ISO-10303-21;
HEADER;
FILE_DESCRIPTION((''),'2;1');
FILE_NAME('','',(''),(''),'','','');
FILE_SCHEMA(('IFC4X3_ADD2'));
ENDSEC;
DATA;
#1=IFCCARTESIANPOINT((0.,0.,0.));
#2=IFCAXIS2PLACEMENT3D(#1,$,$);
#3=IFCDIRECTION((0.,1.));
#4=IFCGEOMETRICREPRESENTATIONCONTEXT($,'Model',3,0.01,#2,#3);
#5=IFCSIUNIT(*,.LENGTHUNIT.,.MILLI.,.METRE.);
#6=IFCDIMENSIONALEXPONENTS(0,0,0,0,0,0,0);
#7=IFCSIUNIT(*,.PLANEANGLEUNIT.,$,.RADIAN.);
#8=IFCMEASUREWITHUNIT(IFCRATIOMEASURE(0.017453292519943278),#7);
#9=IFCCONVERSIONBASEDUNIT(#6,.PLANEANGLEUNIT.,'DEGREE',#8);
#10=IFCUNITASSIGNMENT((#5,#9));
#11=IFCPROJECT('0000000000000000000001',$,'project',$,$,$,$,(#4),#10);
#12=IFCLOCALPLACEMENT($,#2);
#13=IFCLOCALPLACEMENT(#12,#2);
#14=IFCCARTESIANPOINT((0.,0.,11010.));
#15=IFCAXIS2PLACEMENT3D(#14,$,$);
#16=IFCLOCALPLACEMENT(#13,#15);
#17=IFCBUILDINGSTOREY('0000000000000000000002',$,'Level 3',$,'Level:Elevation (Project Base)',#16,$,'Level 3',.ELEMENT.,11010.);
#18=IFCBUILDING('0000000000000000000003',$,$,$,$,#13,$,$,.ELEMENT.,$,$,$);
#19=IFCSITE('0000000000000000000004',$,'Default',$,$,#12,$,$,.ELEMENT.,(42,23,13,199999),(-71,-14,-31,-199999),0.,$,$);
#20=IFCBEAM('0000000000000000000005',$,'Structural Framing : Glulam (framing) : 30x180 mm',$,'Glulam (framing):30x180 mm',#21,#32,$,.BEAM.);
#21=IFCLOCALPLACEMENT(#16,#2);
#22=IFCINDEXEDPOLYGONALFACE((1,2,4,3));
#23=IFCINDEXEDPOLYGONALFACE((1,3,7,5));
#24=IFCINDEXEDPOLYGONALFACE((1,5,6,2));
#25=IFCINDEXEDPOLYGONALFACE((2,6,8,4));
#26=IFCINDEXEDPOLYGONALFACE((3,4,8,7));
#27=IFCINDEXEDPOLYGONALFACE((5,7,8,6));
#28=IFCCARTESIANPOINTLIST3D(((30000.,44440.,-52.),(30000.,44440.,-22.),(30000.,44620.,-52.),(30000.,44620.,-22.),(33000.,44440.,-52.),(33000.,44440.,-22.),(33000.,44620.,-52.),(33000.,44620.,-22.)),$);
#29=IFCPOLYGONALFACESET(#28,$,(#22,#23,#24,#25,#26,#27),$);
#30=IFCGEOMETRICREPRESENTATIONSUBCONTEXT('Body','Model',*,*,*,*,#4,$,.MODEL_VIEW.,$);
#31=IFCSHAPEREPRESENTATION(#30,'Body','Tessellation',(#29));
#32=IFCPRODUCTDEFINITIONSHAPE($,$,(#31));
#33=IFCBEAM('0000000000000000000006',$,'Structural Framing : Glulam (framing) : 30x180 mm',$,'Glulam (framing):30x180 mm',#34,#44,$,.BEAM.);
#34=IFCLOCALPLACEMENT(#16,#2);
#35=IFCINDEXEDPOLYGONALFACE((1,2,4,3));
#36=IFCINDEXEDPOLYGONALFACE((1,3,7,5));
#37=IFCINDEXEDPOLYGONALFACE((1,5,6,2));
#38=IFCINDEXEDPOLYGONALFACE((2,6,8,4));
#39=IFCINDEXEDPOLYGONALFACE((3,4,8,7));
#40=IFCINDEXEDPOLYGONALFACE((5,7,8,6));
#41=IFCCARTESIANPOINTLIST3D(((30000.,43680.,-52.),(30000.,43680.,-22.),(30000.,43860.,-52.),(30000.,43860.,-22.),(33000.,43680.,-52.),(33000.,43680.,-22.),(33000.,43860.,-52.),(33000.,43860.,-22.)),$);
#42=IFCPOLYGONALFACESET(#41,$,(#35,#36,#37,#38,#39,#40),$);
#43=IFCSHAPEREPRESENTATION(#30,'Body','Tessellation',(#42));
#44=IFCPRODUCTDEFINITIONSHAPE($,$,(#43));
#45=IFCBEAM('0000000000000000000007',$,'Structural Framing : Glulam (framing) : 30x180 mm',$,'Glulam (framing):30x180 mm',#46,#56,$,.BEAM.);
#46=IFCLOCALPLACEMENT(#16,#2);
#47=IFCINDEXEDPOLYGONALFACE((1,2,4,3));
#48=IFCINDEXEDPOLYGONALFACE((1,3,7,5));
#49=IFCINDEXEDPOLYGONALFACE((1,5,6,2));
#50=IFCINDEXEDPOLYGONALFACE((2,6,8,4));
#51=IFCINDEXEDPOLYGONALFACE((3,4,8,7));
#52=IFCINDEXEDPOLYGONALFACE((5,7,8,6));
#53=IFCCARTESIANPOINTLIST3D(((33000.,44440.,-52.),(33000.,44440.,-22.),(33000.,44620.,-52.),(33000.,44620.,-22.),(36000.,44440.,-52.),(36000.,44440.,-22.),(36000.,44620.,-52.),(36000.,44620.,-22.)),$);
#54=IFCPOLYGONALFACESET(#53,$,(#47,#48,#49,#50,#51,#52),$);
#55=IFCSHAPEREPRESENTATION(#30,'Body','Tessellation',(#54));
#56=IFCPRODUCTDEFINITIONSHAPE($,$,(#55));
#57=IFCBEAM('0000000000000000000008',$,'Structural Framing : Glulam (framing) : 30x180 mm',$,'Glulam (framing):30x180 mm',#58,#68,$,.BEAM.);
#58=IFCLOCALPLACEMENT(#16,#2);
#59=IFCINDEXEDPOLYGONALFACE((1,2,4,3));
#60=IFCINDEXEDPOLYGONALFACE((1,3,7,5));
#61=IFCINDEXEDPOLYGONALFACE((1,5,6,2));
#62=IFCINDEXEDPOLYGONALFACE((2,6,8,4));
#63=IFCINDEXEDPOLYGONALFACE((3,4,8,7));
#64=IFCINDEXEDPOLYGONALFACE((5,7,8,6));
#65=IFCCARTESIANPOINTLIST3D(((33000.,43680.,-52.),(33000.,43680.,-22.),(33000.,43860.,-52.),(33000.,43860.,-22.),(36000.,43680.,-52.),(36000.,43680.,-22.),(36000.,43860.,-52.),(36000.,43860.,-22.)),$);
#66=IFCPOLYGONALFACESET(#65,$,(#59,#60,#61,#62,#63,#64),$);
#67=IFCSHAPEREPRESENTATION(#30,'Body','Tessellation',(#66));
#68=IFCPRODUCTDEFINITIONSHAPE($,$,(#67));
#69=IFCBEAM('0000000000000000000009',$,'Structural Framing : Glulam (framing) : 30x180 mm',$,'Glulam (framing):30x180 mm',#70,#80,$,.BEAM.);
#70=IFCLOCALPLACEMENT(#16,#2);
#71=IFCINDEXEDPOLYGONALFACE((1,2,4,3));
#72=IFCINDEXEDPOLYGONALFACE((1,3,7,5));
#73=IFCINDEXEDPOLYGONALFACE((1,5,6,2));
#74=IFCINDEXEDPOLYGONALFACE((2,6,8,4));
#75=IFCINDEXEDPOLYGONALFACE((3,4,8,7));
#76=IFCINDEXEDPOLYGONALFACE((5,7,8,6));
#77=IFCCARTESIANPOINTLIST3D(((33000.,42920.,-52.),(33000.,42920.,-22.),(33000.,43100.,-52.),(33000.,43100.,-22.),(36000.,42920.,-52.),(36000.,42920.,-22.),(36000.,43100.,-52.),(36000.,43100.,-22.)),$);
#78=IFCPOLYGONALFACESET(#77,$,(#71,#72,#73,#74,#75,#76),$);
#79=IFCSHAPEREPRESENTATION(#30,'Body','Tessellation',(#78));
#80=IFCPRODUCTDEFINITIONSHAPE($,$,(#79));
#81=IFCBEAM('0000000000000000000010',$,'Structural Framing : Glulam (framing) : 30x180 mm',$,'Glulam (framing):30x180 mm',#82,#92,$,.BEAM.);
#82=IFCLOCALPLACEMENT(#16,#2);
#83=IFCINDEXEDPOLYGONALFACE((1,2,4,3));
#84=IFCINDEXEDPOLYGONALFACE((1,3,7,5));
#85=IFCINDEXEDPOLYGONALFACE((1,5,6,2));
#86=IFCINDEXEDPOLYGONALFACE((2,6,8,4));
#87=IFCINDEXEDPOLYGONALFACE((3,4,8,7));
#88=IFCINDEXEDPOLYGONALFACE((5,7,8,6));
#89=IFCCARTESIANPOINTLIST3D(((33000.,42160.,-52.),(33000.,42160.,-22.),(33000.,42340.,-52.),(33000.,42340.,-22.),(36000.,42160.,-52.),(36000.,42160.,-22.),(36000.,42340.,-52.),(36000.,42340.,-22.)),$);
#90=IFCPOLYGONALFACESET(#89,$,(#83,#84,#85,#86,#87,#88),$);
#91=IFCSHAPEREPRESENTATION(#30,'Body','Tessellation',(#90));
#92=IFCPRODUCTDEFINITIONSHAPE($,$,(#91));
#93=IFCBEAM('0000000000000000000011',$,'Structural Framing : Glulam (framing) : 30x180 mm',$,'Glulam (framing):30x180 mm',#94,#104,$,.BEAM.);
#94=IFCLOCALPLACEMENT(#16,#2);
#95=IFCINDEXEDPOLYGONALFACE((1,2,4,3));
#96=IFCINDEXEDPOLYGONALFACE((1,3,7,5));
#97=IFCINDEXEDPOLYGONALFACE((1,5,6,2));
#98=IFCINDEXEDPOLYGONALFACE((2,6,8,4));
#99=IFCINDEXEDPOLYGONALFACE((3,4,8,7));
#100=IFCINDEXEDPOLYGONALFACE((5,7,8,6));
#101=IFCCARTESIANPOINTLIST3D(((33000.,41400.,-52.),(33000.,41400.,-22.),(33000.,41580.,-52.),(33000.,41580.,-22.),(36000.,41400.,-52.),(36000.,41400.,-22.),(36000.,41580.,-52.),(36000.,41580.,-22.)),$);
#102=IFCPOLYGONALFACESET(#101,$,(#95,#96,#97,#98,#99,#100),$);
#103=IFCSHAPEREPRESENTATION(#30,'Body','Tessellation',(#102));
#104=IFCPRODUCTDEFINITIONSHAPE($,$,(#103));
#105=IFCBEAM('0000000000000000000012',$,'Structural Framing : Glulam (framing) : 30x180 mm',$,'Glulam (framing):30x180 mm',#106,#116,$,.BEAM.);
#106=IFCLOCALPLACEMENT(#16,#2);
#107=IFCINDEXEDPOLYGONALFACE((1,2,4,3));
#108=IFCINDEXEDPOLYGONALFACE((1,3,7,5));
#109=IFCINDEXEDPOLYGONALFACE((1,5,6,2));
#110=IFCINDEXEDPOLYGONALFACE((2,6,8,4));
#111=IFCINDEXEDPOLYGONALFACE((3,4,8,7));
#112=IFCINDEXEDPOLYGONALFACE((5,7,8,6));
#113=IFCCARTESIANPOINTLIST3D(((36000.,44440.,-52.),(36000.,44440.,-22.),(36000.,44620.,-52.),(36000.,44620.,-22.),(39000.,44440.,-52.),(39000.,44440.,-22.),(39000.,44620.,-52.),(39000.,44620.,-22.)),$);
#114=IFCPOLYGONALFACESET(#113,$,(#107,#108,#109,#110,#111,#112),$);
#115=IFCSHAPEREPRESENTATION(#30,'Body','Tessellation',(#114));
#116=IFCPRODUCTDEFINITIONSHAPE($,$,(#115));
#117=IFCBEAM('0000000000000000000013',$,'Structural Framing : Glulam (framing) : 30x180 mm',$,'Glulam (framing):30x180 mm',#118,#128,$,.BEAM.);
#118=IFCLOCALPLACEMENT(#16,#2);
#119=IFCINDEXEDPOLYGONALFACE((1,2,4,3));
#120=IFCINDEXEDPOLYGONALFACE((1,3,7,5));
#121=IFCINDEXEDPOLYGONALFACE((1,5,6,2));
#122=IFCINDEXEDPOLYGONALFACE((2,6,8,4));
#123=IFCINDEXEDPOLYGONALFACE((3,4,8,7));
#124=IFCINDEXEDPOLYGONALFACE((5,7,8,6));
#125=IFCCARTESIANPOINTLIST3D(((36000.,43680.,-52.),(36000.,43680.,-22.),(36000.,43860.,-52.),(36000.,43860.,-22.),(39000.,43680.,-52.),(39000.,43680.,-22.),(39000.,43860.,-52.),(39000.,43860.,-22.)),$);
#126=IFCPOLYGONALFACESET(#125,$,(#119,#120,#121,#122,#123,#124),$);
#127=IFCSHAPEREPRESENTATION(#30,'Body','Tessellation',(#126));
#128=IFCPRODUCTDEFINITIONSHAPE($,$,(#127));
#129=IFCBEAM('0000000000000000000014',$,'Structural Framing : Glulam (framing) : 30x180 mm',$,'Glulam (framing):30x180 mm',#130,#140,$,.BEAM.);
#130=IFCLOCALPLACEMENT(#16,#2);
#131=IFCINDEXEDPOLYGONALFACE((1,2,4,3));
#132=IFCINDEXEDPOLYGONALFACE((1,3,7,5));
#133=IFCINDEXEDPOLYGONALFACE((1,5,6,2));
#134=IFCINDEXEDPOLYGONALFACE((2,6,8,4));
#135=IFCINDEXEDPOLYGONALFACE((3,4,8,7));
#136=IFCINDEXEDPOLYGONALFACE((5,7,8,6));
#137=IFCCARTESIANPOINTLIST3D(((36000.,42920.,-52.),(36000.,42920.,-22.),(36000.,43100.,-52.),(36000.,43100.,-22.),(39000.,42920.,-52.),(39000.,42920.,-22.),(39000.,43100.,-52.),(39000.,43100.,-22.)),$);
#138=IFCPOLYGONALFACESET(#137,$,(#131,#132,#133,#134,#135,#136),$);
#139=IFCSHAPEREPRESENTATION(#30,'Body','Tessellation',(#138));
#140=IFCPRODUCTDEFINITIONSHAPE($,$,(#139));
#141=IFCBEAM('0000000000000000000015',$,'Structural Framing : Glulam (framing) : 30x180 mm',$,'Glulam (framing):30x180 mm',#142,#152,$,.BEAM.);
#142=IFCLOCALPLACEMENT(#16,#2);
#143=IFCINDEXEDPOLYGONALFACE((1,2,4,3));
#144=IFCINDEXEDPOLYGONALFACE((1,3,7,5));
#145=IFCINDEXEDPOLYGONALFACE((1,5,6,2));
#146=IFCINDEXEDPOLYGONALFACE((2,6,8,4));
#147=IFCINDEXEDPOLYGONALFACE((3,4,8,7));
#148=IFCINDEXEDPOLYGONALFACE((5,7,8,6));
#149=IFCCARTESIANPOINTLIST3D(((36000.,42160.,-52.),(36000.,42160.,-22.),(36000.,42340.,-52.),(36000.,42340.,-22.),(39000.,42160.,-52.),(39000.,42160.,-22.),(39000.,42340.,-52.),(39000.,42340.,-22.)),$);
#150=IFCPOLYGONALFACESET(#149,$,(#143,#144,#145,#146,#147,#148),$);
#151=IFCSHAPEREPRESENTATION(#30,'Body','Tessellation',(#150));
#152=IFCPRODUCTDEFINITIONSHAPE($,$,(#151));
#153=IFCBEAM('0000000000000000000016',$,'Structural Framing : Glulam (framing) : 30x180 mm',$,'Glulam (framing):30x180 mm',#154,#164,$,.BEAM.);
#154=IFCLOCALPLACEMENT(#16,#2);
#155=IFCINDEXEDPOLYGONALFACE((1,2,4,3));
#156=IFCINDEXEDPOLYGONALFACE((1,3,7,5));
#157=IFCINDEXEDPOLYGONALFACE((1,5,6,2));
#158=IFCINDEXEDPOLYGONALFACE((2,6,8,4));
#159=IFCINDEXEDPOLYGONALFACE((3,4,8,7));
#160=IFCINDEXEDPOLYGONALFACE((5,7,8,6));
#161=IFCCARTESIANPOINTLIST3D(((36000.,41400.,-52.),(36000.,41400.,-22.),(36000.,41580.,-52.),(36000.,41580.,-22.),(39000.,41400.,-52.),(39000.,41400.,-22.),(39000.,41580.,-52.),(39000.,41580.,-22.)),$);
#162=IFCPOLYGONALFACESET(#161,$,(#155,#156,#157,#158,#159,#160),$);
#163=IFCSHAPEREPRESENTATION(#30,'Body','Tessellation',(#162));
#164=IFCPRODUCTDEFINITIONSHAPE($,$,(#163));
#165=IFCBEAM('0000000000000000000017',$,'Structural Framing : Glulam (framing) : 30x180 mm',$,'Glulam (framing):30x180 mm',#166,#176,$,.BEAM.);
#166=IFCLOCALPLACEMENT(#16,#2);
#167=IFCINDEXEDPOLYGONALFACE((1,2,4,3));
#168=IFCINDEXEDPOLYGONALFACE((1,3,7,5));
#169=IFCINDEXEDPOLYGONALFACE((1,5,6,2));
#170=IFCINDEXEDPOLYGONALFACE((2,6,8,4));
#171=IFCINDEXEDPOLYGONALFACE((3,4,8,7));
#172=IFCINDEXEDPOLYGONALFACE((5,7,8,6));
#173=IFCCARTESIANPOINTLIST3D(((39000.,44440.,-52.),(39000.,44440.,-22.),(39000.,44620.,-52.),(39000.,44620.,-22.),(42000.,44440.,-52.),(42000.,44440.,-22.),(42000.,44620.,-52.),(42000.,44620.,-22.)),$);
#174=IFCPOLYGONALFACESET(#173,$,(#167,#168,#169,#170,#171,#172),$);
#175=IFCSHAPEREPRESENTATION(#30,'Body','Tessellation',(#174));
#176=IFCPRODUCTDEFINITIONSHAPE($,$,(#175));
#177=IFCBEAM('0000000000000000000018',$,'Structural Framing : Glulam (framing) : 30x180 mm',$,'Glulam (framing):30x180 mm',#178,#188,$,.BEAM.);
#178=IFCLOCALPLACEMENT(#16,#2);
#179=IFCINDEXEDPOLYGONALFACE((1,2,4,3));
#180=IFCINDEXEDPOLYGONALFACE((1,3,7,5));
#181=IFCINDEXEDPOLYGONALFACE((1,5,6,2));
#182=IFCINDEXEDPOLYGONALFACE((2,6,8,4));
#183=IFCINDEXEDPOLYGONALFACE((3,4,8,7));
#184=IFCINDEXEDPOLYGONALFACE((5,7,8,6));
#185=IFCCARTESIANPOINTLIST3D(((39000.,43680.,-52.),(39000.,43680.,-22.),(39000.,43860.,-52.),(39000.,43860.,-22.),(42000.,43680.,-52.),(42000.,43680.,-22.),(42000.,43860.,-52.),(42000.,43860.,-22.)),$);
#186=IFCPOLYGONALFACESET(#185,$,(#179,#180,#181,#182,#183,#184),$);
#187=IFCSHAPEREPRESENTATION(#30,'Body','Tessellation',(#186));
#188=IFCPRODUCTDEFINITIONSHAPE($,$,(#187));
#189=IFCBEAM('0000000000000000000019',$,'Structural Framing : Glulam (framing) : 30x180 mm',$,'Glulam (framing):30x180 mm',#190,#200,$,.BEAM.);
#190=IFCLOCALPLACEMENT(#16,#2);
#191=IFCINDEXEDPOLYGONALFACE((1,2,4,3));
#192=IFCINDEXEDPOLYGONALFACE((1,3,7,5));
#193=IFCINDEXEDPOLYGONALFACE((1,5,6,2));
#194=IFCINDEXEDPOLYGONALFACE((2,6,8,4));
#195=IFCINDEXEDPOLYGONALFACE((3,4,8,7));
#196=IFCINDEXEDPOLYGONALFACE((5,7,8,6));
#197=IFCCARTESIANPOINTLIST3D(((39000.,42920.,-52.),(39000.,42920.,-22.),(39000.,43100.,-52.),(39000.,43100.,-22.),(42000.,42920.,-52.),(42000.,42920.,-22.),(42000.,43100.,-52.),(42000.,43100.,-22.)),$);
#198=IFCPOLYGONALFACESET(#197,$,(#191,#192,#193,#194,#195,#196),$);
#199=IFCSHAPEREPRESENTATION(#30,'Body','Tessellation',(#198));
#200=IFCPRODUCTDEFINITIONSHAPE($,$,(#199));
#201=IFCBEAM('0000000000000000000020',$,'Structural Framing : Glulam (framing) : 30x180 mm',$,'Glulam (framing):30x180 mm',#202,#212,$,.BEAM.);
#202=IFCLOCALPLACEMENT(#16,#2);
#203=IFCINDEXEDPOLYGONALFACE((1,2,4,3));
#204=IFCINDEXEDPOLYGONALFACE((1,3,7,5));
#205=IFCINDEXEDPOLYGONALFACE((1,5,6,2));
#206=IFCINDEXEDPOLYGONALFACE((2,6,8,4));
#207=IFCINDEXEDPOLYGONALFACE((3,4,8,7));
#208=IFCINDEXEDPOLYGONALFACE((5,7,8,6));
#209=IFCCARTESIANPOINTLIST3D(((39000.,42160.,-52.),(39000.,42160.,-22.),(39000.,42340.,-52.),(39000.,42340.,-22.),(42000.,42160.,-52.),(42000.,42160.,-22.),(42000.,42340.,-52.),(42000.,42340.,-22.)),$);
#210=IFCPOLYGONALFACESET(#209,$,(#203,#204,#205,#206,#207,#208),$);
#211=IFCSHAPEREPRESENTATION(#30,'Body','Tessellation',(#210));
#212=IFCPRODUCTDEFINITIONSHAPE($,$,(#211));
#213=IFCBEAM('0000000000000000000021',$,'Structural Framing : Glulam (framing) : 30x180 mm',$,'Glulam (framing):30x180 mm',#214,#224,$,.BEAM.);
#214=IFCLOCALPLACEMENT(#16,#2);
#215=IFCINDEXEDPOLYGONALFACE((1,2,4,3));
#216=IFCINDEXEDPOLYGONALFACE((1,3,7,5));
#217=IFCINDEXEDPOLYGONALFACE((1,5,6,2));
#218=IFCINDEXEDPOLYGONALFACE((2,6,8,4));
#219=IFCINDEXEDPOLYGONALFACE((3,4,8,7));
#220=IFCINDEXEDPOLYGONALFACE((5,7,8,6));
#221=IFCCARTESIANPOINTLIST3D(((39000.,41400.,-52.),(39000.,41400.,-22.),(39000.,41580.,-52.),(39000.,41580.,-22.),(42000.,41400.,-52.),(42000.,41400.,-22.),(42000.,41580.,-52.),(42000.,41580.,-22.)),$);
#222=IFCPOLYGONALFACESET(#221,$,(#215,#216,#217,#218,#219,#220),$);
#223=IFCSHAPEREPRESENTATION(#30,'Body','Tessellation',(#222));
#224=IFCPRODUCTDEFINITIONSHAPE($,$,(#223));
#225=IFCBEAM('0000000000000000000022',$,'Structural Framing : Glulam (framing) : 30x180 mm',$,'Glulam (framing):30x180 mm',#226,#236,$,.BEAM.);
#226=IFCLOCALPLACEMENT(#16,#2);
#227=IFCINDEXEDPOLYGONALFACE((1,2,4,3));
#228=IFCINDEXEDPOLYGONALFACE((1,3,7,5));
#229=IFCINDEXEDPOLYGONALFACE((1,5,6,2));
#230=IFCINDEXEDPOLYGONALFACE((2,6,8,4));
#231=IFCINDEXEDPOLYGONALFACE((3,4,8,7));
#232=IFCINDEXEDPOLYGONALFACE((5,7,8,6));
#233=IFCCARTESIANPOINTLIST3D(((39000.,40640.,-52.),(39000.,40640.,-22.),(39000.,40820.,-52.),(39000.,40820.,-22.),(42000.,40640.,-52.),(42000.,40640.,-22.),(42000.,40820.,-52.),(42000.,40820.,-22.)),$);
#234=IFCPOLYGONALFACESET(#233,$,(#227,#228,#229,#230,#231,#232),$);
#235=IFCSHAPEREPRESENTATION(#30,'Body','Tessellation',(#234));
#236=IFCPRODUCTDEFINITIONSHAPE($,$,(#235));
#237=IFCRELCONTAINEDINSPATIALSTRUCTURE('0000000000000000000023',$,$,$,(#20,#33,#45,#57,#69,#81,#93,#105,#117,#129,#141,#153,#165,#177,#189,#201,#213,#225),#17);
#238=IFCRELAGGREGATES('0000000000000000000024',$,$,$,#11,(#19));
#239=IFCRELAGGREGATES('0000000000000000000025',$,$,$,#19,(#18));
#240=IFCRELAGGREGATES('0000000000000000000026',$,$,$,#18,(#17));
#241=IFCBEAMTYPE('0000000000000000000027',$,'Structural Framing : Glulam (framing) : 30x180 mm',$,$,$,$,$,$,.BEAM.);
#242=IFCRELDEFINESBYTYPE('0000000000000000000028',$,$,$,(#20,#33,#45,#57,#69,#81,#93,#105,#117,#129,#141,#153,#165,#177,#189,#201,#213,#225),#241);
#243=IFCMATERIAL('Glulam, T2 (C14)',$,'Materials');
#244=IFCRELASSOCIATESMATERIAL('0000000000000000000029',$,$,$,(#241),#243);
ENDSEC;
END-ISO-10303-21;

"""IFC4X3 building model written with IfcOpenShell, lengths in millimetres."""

from ifc_helpers import new_model, entity, si_unit, converted_unit, direction, frame, origin, origin_2d_with_axis, place, context, subcontext, project, spatial, rectangle, extrude, source, transform, mapped, material, material_profile, profile_set, type_object, type_shapes, element, save


model = new_model("IFC4X3")

# Units and contexts
model_context = context("Model", 3, precision=0.01, world=origin(), true_north=direction((0.0, 1.0)))
body_context = subcontext(model_context, "Body", "Model", "MODEL_VIEW")
ifc_project = project(units=[si_unit("LENGTHUNIT", "METRE", prefix="MILLI"), converted_unit("PLANEANGLEUNIT", "DEGREE", entity("IfcRatioMeasure", 0.017453292519943278), si_unit("PLANEANGLEUNIT", "RADIAN"), dimensions=[0, 0, 0, 0, 0, 0, 0])], contexts=[model_context])

# Site, building, storey
site_placement = place(None, origin())
site = spatial("IfcSite", under=ifc_project, at=site_placement, Name="Default", CompositionType="ELEMENT", RefLatitude=(42, 23, 13, 199999), RefLongitude=(-71, -14, -31, -199999), RefElevation=0.0)
building_placement = place(site_placement, origin())
building = spatial("IfcBuilding", under=site, at=building_placement, CompositionType="ELEMENT")
storey_placement = place(building_placement, frame((0.0, 0.0, 11010.0)))
storey = spatial("IfcBuildingStorey", under=building, at=storey_placement, Name="Level 3", ObjectType="Level:Elevation (Project Base)", LongName="Level 3", CompositionType="ELEMENT", Elevation=11010.0)

# Beams
ifc_material_1 = material(Name="Glulam, T2 (C14)", Category="Materials")
ifc_material_profile_1 = material_profile(ifc_material_1, rectangle(XDim=30.0, YDim=180.0, at=origin_2d_with_axis()), Name="30x180 mm")
ifc_profile_set_1 = profile_set([ifc_material_profile_1], Name="30x180 mm")
beam_type_1 = type_object("IfcBeamType", Name="Structural Framing : Glulam (framing) : 30x180 mm", PredefinedType="BEAM", material=ifc_profile_set_1)
shared_shape_1 = source(origin(), body_context, "Body", "SweptSolid", [
    extrude(rectangle(XDim=30.0, YDim=180.0, at=origin_2d_with_axis()), frame((500.0, 0.0, 0.0), z_axis=(1.0, 0.0, 0.0), x_axis=(0.0, 0.0, -1.0)), (0.0, 0.0, 1.0), 3000.0),
])
type_shapes(beam_type_1, [shared_shape_1])
for number, where, name in (
    (1, (29500.0, 44530.0, -37.0), "Structural Framing : Glulam (framing) : 30x180 mm"),
    (2, (29500.0, 43770.0, -37.0), "Structural Framing : Glulam (framing) : 30x180 mm"),
    (3, (32500.0, 44530.0, -37.0), "Structural Framing : Glulam (framing) : 30x180 mm"),
    (4, (32500.0, 43770.0, -37.0), "Structural Framing : Glulam (framing) : 30x180 mm"),
    (5, (32500.0, 43010.0, -37.0), "Structural Framing : Glulam (framing) : 30x180 mm"),
    (6, (32500.0, 42250.0, -37.0), "Structural Framing : Glulam (framing) : 30x180 mm"),
    (7, (32500.0, 41490.0, -37.0), "Structural Framing : Glulam (framing) : 30x180 mm"),
    (8, (35500.0, 44530.0, -37.0), "Structural Framing : Glulam (framing) : 30x180 mm"),
    (9, (35500.0, 43770.0, -37.0), "Structural Framing : Glulam (framing) : 30x180 mm"),
    (10, (35500.0, 43010.0, -37.0), "Structural Framing : Glulam (framing) : 30x180 mm"),
    (11, (35500.0, 42250.0, -37.0), "Structural Framing : Glulam (framing) : 30x180 mm"),
    (12, (35500.0, 41490.0, -37.0), "Structural Framing : Glulam (framing) : 30x180 mm"),
    (13, (38500.0, 44530.0, -37.0), "Structural Framing : Glulam (framing) : 30x180 mm"),
    (14, (38500.0, 43770.0, -37.0), "Structural Framing : Glulam (framing) : 30x180 mm"),
    (15, (38500.0, 43010.0, -37.0), "Structural Framing : Glulam (framing) : 30x180 mm"),
    (16, (38500.0, 42250.0, -37.0), "Structural Framing : Glulam (framing) : 30x180 mm"),
    (17, (38500.0, 41490.0, -37.0), "Structural Framing : Glulam (framing) : 30x180 mm"),
    (18, (38500.0, 40730.0, -37.0), "Structural Framing : Glulam (framing) : 30x180 mm"),
):
    element("IfcBeam", number, at=place(storey_placement, frame(where)), inside=storey, type_object=beam_type_1, Name=name, ObjectType="Glulam (framing):30x180 mm", PredefinedType="BEAM", context=body_context, shape_type="MappedRepresentation", body=[
        mapped(shared_shape_1, transform((0.0, 0.0, 0.0), scale=1.0)),
    ])

save(model, "model.ifc")
